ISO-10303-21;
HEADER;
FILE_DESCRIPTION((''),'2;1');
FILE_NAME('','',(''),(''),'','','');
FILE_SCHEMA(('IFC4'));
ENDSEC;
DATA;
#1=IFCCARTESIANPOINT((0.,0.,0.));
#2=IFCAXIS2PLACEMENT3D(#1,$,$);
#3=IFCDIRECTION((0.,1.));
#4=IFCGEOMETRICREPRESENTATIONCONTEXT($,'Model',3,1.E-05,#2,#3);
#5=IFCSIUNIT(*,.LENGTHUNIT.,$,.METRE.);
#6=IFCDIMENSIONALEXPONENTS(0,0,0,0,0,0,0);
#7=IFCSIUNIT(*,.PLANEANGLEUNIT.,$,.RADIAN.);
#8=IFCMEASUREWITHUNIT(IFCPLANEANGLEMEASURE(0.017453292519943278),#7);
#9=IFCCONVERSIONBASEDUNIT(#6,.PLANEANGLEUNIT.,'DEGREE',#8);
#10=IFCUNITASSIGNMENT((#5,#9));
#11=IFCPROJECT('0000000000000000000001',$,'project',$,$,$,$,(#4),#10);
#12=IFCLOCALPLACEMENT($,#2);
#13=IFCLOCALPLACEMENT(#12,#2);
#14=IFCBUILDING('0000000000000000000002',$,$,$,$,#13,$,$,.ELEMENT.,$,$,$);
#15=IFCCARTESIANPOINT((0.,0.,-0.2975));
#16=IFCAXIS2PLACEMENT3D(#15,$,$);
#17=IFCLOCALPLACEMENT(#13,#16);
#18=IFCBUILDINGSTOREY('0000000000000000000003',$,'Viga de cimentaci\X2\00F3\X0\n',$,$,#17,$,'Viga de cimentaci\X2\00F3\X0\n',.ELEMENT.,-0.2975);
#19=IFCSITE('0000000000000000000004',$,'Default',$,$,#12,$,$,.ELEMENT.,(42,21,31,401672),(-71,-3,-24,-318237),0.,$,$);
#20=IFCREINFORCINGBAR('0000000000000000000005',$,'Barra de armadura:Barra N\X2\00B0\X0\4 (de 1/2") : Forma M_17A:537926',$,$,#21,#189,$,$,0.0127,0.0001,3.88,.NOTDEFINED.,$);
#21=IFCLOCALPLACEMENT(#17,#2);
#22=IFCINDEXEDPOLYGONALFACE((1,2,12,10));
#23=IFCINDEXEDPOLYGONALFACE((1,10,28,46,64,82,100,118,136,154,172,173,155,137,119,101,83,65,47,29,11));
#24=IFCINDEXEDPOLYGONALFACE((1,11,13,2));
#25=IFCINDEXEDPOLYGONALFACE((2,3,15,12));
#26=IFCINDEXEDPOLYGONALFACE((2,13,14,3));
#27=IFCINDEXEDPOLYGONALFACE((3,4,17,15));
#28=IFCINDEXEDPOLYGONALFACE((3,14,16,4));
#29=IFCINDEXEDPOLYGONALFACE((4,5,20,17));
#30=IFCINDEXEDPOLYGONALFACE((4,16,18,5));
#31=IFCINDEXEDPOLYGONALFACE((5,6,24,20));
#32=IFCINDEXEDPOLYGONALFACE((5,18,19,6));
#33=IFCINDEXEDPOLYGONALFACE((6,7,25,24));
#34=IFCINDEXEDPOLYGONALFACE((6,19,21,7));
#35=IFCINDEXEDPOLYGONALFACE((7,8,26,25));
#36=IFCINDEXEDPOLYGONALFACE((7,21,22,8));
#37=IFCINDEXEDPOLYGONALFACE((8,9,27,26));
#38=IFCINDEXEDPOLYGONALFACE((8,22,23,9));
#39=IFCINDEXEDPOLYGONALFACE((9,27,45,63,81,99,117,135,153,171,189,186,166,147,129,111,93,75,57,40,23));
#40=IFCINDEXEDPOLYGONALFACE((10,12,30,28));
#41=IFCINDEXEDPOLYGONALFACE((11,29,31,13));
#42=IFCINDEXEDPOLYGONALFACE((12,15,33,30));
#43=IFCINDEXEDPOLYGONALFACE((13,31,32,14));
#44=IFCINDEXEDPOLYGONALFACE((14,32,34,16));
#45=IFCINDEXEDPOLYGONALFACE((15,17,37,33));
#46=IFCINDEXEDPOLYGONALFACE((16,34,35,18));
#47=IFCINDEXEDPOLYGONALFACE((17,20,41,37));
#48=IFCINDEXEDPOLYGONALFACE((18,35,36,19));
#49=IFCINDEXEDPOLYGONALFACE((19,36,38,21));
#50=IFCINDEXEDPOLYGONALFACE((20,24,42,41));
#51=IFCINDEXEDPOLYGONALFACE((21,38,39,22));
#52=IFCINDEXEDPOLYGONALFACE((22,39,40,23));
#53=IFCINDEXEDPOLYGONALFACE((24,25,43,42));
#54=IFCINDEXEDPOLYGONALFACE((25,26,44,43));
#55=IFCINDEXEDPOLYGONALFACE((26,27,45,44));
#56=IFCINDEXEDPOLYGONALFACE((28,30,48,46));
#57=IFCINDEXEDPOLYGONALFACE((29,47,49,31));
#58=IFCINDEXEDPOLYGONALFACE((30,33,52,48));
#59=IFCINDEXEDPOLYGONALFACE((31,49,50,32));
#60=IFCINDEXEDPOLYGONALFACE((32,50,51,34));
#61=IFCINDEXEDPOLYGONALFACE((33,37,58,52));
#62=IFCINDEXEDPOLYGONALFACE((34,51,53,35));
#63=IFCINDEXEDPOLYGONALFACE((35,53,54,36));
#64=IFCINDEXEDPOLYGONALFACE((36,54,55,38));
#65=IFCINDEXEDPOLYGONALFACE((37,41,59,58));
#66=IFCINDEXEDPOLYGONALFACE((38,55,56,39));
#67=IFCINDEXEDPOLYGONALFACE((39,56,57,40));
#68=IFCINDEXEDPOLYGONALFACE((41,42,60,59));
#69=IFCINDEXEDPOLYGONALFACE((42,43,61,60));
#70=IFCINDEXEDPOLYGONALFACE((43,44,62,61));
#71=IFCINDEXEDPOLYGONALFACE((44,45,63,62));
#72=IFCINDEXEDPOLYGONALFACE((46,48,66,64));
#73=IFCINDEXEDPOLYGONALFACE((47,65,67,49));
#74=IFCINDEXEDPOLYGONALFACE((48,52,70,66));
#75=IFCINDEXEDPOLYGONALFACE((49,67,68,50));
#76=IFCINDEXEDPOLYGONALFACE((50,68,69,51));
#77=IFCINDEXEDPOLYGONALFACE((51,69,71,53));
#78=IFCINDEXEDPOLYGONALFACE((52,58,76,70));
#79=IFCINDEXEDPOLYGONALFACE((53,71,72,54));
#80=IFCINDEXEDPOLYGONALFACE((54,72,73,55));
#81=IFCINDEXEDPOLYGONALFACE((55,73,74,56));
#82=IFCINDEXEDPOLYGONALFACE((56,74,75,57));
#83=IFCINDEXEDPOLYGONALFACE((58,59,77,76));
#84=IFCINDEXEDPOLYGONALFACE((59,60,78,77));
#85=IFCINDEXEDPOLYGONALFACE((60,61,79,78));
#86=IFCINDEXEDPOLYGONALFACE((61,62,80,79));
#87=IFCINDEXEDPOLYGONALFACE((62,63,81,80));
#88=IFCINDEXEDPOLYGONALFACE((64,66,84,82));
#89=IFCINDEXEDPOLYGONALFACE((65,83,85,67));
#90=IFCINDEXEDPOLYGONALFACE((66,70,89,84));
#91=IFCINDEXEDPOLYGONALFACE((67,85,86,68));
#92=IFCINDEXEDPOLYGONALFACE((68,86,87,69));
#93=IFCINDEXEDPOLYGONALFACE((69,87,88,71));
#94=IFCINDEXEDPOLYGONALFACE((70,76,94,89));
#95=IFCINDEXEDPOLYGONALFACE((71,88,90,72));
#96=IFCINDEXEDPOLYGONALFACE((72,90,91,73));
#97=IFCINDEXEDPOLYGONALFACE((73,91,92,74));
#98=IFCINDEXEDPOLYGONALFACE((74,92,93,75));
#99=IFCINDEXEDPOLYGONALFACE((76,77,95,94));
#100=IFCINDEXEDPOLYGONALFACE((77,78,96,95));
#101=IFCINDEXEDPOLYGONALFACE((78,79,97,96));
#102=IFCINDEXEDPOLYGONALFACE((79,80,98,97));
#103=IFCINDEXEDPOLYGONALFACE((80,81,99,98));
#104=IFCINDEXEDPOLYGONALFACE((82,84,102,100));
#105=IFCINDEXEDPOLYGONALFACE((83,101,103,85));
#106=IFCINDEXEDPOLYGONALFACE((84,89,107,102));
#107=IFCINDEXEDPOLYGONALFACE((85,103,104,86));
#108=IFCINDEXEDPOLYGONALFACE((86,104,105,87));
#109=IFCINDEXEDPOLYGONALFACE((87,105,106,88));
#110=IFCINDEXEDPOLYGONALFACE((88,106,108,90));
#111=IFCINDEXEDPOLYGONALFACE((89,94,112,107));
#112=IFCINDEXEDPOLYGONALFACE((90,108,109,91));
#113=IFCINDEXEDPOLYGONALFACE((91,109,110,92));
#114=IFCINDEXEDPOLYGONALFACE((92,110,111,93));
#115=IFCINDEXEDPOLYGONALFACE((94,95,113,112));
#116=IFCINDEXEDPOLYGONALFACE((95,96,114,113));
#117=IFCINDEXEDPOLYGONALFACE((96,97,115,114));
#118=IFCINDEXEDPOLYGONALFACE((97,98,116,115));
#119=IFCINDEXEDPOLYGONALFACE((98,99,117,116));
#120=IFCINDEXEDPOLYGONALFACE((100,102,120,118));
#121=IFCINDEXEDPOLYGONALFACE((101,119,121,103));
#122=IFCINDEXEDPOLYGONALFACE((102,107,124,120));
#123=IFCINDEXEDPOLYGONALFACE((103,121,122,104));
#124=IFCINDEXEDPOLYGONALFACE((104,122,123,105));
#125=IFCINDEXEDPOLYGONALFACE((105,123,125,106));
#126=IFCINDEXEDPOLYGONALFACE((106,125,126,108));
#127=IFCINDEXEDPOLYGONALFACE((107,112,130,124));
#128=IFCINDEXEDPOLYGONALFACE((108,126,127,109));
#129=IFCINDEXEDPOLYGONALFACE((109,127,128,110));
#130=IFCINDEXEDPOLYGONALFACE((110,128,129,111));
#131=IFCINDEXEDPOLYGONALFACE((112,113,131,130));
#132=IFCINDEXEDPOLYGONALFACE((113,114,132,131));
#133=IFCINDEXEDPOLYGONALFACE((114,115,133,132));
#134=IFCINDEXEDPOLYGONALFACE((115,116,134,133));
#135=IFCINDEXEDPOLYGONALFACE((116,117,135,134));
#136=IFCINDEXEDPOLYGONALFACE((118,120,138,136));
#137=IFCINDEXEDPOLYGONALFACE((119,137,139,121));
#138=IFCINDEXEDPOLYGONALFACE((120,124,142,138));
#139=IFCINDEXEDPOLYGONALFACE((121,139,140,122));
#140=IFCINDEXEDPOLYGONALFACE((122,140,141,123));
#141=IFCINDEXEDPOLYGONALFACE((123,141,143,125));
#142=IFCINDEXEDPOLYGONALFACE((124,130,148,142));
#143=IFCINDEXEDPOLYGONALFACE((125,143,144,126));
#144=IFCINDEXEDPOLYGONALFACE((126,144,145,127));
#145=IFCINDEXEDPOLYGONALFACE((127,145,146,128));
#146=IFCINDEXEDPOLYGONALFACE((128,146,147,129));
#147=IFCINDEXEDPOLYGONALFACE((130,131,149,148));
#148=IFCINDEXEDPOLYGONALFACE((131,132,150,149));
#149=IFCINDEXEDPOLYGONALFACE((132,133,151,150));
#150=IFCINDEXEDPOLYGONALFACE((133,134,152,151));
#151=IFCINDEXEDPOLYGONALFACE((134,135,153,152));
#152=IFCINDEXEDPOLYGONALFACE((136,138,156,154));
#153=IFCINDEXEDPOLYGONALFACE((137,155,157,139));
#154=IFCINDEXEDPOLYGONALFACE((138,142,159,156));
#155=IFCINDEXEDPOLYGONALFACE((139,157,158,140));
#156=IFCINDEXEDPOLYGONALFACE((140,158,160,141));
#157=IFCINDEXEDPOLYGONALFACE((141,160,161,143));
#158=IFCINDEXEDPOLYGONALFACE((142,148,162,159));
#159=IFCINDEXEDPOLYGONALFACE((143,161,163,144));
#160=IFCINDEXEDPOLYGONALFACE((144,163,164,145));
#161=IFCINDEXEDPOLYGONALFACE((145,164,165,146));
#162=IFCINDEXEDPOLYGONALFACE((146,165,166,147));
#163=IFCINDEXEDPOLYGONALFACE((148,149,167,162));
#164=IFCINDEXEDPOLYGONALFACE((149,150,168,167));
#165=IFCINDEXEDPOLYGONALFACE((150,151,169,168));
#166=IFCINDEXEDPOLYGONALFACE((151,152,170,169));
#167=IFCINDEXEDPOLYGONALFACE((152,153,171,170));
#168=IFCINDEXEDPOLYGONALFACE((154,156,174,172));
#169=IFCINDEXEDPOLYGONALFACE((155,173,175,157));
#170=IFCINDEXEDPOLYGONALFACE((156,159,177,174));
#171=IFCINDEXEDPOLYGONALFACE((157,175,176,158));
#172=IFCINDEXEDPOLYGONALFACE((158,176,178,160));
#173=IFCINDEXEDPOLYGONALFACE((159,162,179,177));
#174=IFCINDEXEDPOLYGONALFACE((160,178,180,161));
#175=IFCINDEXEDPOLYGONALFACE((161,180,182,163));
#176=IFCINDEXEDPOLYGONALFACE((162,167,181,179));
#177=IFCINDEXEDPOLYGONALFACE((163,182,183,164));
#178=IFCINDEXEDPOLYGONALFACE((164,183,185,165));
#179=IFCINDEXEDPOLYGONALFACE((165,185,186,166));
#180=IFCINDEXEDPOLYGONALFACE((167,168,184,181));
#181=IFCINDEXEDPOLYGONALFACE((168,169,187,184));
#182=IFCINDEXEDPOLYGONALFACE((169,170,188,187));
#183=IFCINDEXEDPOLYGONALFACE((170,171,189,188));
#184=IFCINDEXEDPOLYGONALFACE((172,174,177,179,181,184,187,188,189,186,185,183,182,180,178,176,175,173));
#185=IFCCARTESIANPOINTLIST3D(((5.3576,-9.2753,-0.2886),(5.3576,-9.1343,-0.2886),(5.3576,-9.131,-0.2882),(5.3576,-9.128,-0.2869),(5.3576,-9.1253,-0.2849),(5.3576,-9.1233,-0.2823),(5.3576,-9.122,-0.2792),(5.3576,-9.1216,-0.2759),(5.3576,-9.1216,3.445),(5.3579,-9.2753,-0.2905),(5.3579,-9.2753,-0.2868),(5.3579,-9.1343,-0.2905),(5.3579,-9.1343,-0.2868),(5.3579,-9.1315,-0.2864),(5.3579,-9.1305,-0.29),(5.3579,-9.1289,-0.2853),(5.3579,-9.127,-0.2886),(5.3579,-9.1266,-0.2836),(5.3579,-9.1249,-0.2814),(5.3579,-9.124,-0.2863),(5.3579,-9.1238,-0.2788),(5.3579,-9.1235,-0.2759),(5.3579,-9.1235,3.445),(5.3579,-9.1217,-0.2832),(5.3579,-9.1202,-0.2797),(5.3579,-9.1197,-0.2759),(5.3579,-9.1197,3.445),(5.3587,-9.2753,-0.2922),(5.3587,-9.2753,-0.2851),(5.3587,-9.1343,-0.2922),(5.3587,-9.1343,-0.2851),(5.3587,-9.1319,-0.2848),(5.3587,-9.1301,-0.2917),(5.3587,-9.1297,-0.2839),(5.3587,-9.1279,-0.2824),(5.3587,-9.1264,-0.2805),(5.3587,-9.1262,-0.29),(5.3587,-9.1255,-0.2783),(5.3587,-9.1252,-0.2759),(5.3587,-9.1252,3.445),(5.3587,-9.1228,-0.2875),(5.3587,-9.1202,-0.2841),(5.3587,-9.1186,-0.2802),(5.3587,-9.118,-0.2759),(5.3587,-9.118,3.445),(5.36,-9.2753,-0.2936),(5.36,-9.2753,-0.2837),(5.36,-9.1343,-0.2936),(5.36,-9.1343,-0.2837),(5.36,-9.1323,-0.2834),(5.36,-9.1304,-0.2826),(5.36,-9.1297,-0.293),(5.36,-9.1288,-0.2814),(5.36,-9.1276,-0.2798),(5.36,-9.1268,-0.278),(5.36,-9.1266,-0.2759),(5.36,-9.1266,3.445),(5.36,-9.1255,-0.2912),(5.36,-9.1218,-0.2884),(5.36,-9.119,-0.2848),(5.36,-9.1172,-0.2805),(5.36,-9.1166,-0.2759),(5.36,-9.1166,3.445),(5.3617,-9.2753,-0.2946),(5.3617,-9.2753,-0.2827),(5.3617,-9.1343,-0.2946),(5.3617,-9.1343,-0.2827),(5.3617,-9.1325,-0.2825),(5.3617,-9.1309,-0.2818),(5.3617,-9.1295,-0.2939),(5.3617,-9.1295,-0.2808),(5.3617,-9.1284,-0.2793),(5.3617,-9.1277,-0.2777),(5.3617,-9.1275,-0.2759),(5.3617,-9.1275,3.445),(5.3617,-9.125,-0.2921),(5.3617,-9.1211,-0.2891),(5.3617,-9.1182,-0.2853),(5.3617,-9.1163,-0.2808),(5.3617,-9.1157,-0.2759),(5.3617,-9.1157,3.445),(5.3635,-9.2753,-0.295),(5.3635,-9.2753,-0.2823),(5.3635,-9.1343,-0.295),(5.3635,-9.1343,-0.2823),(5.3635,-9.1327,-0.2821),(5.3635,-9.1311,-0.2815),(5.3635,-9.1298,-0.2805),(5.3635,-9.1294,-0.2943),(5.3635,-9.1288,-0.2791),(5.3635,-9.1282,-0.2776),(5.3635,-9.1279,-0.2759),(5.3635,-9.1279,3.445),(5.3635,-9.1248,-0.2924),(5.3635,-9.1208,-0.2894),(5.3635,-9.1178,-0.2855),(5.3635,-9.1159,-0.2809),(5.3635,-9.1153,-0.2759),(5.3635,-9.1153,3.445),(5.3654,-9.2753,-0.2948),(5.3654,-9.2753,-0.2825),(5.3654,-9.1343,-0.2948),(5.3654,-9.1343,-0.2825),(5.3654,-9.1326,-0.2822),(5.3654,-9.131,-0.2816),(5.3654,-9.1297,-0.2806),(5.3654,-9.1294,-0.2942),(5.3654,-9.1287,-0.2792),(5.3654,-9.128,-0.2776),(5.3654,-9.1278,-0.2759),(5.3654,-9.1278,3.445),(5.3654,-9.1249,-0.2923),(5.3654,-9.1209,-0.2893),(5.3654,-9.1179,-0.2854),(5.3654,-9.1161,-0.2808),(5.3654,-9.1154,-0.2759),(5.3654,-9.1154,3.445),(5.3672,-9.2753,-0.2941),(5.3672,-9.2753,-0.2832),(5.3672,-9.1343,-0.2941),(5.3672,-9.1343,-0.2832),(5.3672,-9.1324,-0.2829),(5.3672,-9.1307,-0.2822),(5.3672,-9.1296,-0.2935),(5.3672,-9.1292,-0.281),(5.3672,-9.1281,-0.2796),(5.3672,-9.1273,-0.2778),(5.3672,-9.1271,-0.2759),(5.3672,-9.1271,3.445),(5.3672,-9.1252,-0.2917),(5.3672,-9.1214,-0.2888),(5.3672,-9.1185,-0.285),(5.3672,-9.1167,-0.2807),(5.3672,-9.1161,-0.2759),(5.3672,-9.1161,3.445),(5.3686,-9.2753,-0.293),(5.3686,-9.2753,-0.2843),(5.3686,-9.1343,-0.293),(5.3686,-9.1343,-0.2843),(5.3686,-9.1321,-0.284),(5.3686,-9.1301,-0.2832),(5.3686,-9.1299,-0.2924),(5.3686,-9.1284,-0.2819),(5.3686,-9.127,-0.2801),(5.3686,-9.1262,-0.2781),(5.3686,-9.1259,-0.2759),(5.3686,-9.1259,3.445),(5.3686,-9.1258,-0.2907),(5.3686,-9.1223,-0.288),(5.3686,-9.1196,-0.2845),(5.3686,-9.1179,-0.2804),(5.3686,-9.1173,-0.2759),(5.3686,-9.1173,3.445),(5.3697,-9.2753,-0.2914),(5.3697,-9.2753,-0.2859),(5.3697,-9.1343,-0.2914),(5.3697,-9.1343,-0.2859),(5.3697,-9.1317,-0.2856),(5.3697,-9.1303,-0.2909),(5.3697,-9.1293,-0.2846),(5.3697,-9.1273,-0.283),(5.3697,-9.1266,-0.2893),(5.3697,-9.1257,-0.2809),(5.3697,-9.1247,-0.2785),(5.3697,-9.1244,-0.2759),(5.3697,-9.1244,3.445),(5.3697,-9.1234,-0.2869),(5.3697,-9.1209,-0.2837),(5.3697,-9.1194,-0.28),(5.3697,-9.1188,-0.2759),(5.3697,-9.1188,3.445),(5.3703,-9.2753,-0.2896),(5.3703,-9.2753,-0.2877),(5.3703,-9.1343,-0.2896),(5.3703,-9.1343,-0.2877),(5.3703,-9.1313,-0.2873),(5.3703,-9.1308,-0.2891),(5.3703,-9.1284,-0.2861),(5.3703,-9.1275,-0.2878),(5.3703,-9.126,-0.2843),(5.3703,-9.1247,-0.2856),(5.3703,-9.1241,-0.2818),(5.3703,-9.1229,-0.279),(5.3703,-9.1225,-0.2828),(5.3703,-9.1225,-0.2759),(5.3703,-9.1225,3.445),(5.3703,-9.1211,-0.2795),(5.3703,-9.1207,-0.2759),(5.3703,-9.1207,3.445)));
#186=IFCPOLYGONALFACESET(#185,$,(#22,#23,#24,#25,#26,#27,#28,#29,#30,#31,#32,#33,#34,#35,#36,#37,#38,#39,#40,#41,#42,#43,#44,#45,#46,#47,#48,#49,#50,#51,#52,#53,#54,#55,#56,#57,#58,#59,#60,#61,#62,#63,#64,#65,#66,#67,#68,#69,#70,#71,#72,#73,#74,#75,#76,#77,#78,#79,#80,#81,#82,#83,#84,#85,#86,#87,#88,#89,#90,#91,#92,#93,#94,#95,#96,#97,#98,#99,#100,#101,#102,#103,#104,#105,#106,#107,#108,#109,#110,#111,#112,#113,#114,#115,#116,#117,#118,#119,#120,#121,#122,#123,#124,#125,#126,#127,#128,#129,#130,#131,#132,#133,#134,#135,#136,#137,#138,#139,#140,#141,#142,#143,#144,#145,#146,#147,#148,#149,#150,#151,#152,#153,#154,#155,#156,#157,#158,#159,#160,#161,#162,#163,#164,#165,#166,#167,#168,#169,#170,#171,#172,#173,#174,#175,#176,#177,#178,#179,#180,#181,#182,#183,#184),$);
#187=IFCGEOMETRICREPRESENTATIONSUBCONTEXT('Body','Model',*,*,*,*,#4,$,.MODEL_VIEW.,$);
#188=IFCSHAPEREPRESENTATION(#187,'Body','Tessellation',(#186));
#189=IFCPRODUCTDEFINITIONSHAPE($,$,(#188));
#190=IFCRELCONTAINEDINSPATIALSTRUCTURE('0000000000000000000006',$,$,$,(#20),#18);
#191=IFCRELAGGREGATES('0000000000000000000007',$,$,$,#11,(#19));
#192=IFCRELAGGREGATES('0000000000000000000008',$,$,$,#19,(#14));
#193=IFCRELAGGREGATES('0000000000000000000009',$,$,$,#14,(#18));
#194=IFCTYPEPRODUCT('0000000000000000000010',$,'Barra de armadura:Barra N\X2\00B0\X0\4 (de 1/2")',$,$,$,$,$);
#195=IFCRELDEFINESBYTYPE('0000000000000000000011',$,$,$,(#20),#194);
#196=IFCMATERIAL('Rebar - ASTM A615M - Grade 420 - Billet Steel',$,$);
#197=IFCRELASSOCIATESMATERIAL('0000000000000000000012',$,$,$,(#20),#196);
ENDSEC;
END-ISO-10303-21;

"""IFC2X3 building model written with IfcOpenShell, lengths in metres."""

from ifc_helpers import new_model, entity, si_unit, converted_unit, direction, frame, origin, place, context, subcontext, project, spatial, material, type_object, element, save


model = new_model("IFC2X3")

# Units and contexts
model_context = context("Model", 3, precision=1e-05, world=origin(), true_north=direction((0.0, 1.0)))
body_context = subcontext(model_context, "Body", "Model", "MODEL_VIEW")
ifc_project = project(units=[si_unit("LENGTHUNIT", "METRE"), converted_unit("PLANEANGLEUNIT", "DEGREE", entity("IfcPlaneAngleMeasure", 0.017453292519943278), si_unit("PLANEANGLEUNIT", "RADIAN"), dimensions=[0, 0, 0, 0, 0, 0, 0])], contexts=[model_context])

# Site, building, storey
site_placement = place(None, origin())
site = spatial("IfcSite", under=ifc_project, at=site_placement, Name="Default", CompositionType="ELEMENT", RefLatitude=(42, 21, 31, 401672), RefLongitude=(-71, -3, -24, -318237), RefElevation=0.0)
building_placement = place(site_placement, origin())
building = spatial("IfcBuilding", under=site, at=building_placement, CompositionType="ELEMENT")
storey_placement = place(building_placement, frame((0.0, 0.0, -0.2975)))
storey = spatial("IfcBuildingStorey", under=building, at=storey_placement, Name="Viga de cimentación", LongName="Viga de cimentación", CompositionType="ELEMENT", Elevation=-0.2975)

# Reinforcing bar
ifc_material_1 = material(Name="Rebar - ASTM A615M - Grade 420 - Billet Steel")
type_product_1 = type_object("IfcTypeProduct", Name="Barra de armadura:Barra N°4 (de 1/2\")")
reinforcing_bar_1_placement = place(storey_placement, origin())
element("IfcReinforcingBar", 1, at=reinforcing_bar_1_placement, inside=storey, type_object=type_product_1, material=ifc_material_1, Name="Barra de armadura:Barra N°4 (de 1/2\") : Forma M_17A:537926", BarLength=3.88, BarRole="NOTDEFINED", CrossSectionArea=0.0001, NominalDiameter=0.0127, context=body_context, shape_type="AdvancedSweptSolid", body=[
    entity("IfcSweptDiskSolid", entity("IfcCompositeCurve", [entity("IfcCompositeCurveSegment", "CONTINUOUS", True, entity("IfcPolyline", [entity("IfcCartesianPoint", [5.364, -9.1216, 3.445]), entity("IfcCartesianPoint", [5.364, -9.1216, -0.2759])])), entity("IfcCompositeCurveSegment", "CONTINUOUS", True, entity("IfcTrimmedCurve", entity("IfcCircle", entity("IfcAxis2Placement3D", entity("IfcCartesianPoint", [5.364, -9.1343, -0.2759]), entity("IfcDirection", [-1.0, 0.0, 0.0]), entity("IfcDirection", [0.0, 0.0, -1.0])), 0.0127), [entity("IfcParameterValue", 270.0)], [entity("IfcParameterValue", 360.0)], True, "PARAMETER")), entity("IfcCompositeCurveSegment", "CONTINUOUS", True, entity("IfcPolyline", [entity("IfcCartesianPoint", [5.364, -9.1343, -0.2886]), entity("IfcCartesianPoint", [5.364, -9.2753, -0.2886])]))], False), 0.0063, None, 0.0, 92.0),
])

save(model, "model.ifc")
